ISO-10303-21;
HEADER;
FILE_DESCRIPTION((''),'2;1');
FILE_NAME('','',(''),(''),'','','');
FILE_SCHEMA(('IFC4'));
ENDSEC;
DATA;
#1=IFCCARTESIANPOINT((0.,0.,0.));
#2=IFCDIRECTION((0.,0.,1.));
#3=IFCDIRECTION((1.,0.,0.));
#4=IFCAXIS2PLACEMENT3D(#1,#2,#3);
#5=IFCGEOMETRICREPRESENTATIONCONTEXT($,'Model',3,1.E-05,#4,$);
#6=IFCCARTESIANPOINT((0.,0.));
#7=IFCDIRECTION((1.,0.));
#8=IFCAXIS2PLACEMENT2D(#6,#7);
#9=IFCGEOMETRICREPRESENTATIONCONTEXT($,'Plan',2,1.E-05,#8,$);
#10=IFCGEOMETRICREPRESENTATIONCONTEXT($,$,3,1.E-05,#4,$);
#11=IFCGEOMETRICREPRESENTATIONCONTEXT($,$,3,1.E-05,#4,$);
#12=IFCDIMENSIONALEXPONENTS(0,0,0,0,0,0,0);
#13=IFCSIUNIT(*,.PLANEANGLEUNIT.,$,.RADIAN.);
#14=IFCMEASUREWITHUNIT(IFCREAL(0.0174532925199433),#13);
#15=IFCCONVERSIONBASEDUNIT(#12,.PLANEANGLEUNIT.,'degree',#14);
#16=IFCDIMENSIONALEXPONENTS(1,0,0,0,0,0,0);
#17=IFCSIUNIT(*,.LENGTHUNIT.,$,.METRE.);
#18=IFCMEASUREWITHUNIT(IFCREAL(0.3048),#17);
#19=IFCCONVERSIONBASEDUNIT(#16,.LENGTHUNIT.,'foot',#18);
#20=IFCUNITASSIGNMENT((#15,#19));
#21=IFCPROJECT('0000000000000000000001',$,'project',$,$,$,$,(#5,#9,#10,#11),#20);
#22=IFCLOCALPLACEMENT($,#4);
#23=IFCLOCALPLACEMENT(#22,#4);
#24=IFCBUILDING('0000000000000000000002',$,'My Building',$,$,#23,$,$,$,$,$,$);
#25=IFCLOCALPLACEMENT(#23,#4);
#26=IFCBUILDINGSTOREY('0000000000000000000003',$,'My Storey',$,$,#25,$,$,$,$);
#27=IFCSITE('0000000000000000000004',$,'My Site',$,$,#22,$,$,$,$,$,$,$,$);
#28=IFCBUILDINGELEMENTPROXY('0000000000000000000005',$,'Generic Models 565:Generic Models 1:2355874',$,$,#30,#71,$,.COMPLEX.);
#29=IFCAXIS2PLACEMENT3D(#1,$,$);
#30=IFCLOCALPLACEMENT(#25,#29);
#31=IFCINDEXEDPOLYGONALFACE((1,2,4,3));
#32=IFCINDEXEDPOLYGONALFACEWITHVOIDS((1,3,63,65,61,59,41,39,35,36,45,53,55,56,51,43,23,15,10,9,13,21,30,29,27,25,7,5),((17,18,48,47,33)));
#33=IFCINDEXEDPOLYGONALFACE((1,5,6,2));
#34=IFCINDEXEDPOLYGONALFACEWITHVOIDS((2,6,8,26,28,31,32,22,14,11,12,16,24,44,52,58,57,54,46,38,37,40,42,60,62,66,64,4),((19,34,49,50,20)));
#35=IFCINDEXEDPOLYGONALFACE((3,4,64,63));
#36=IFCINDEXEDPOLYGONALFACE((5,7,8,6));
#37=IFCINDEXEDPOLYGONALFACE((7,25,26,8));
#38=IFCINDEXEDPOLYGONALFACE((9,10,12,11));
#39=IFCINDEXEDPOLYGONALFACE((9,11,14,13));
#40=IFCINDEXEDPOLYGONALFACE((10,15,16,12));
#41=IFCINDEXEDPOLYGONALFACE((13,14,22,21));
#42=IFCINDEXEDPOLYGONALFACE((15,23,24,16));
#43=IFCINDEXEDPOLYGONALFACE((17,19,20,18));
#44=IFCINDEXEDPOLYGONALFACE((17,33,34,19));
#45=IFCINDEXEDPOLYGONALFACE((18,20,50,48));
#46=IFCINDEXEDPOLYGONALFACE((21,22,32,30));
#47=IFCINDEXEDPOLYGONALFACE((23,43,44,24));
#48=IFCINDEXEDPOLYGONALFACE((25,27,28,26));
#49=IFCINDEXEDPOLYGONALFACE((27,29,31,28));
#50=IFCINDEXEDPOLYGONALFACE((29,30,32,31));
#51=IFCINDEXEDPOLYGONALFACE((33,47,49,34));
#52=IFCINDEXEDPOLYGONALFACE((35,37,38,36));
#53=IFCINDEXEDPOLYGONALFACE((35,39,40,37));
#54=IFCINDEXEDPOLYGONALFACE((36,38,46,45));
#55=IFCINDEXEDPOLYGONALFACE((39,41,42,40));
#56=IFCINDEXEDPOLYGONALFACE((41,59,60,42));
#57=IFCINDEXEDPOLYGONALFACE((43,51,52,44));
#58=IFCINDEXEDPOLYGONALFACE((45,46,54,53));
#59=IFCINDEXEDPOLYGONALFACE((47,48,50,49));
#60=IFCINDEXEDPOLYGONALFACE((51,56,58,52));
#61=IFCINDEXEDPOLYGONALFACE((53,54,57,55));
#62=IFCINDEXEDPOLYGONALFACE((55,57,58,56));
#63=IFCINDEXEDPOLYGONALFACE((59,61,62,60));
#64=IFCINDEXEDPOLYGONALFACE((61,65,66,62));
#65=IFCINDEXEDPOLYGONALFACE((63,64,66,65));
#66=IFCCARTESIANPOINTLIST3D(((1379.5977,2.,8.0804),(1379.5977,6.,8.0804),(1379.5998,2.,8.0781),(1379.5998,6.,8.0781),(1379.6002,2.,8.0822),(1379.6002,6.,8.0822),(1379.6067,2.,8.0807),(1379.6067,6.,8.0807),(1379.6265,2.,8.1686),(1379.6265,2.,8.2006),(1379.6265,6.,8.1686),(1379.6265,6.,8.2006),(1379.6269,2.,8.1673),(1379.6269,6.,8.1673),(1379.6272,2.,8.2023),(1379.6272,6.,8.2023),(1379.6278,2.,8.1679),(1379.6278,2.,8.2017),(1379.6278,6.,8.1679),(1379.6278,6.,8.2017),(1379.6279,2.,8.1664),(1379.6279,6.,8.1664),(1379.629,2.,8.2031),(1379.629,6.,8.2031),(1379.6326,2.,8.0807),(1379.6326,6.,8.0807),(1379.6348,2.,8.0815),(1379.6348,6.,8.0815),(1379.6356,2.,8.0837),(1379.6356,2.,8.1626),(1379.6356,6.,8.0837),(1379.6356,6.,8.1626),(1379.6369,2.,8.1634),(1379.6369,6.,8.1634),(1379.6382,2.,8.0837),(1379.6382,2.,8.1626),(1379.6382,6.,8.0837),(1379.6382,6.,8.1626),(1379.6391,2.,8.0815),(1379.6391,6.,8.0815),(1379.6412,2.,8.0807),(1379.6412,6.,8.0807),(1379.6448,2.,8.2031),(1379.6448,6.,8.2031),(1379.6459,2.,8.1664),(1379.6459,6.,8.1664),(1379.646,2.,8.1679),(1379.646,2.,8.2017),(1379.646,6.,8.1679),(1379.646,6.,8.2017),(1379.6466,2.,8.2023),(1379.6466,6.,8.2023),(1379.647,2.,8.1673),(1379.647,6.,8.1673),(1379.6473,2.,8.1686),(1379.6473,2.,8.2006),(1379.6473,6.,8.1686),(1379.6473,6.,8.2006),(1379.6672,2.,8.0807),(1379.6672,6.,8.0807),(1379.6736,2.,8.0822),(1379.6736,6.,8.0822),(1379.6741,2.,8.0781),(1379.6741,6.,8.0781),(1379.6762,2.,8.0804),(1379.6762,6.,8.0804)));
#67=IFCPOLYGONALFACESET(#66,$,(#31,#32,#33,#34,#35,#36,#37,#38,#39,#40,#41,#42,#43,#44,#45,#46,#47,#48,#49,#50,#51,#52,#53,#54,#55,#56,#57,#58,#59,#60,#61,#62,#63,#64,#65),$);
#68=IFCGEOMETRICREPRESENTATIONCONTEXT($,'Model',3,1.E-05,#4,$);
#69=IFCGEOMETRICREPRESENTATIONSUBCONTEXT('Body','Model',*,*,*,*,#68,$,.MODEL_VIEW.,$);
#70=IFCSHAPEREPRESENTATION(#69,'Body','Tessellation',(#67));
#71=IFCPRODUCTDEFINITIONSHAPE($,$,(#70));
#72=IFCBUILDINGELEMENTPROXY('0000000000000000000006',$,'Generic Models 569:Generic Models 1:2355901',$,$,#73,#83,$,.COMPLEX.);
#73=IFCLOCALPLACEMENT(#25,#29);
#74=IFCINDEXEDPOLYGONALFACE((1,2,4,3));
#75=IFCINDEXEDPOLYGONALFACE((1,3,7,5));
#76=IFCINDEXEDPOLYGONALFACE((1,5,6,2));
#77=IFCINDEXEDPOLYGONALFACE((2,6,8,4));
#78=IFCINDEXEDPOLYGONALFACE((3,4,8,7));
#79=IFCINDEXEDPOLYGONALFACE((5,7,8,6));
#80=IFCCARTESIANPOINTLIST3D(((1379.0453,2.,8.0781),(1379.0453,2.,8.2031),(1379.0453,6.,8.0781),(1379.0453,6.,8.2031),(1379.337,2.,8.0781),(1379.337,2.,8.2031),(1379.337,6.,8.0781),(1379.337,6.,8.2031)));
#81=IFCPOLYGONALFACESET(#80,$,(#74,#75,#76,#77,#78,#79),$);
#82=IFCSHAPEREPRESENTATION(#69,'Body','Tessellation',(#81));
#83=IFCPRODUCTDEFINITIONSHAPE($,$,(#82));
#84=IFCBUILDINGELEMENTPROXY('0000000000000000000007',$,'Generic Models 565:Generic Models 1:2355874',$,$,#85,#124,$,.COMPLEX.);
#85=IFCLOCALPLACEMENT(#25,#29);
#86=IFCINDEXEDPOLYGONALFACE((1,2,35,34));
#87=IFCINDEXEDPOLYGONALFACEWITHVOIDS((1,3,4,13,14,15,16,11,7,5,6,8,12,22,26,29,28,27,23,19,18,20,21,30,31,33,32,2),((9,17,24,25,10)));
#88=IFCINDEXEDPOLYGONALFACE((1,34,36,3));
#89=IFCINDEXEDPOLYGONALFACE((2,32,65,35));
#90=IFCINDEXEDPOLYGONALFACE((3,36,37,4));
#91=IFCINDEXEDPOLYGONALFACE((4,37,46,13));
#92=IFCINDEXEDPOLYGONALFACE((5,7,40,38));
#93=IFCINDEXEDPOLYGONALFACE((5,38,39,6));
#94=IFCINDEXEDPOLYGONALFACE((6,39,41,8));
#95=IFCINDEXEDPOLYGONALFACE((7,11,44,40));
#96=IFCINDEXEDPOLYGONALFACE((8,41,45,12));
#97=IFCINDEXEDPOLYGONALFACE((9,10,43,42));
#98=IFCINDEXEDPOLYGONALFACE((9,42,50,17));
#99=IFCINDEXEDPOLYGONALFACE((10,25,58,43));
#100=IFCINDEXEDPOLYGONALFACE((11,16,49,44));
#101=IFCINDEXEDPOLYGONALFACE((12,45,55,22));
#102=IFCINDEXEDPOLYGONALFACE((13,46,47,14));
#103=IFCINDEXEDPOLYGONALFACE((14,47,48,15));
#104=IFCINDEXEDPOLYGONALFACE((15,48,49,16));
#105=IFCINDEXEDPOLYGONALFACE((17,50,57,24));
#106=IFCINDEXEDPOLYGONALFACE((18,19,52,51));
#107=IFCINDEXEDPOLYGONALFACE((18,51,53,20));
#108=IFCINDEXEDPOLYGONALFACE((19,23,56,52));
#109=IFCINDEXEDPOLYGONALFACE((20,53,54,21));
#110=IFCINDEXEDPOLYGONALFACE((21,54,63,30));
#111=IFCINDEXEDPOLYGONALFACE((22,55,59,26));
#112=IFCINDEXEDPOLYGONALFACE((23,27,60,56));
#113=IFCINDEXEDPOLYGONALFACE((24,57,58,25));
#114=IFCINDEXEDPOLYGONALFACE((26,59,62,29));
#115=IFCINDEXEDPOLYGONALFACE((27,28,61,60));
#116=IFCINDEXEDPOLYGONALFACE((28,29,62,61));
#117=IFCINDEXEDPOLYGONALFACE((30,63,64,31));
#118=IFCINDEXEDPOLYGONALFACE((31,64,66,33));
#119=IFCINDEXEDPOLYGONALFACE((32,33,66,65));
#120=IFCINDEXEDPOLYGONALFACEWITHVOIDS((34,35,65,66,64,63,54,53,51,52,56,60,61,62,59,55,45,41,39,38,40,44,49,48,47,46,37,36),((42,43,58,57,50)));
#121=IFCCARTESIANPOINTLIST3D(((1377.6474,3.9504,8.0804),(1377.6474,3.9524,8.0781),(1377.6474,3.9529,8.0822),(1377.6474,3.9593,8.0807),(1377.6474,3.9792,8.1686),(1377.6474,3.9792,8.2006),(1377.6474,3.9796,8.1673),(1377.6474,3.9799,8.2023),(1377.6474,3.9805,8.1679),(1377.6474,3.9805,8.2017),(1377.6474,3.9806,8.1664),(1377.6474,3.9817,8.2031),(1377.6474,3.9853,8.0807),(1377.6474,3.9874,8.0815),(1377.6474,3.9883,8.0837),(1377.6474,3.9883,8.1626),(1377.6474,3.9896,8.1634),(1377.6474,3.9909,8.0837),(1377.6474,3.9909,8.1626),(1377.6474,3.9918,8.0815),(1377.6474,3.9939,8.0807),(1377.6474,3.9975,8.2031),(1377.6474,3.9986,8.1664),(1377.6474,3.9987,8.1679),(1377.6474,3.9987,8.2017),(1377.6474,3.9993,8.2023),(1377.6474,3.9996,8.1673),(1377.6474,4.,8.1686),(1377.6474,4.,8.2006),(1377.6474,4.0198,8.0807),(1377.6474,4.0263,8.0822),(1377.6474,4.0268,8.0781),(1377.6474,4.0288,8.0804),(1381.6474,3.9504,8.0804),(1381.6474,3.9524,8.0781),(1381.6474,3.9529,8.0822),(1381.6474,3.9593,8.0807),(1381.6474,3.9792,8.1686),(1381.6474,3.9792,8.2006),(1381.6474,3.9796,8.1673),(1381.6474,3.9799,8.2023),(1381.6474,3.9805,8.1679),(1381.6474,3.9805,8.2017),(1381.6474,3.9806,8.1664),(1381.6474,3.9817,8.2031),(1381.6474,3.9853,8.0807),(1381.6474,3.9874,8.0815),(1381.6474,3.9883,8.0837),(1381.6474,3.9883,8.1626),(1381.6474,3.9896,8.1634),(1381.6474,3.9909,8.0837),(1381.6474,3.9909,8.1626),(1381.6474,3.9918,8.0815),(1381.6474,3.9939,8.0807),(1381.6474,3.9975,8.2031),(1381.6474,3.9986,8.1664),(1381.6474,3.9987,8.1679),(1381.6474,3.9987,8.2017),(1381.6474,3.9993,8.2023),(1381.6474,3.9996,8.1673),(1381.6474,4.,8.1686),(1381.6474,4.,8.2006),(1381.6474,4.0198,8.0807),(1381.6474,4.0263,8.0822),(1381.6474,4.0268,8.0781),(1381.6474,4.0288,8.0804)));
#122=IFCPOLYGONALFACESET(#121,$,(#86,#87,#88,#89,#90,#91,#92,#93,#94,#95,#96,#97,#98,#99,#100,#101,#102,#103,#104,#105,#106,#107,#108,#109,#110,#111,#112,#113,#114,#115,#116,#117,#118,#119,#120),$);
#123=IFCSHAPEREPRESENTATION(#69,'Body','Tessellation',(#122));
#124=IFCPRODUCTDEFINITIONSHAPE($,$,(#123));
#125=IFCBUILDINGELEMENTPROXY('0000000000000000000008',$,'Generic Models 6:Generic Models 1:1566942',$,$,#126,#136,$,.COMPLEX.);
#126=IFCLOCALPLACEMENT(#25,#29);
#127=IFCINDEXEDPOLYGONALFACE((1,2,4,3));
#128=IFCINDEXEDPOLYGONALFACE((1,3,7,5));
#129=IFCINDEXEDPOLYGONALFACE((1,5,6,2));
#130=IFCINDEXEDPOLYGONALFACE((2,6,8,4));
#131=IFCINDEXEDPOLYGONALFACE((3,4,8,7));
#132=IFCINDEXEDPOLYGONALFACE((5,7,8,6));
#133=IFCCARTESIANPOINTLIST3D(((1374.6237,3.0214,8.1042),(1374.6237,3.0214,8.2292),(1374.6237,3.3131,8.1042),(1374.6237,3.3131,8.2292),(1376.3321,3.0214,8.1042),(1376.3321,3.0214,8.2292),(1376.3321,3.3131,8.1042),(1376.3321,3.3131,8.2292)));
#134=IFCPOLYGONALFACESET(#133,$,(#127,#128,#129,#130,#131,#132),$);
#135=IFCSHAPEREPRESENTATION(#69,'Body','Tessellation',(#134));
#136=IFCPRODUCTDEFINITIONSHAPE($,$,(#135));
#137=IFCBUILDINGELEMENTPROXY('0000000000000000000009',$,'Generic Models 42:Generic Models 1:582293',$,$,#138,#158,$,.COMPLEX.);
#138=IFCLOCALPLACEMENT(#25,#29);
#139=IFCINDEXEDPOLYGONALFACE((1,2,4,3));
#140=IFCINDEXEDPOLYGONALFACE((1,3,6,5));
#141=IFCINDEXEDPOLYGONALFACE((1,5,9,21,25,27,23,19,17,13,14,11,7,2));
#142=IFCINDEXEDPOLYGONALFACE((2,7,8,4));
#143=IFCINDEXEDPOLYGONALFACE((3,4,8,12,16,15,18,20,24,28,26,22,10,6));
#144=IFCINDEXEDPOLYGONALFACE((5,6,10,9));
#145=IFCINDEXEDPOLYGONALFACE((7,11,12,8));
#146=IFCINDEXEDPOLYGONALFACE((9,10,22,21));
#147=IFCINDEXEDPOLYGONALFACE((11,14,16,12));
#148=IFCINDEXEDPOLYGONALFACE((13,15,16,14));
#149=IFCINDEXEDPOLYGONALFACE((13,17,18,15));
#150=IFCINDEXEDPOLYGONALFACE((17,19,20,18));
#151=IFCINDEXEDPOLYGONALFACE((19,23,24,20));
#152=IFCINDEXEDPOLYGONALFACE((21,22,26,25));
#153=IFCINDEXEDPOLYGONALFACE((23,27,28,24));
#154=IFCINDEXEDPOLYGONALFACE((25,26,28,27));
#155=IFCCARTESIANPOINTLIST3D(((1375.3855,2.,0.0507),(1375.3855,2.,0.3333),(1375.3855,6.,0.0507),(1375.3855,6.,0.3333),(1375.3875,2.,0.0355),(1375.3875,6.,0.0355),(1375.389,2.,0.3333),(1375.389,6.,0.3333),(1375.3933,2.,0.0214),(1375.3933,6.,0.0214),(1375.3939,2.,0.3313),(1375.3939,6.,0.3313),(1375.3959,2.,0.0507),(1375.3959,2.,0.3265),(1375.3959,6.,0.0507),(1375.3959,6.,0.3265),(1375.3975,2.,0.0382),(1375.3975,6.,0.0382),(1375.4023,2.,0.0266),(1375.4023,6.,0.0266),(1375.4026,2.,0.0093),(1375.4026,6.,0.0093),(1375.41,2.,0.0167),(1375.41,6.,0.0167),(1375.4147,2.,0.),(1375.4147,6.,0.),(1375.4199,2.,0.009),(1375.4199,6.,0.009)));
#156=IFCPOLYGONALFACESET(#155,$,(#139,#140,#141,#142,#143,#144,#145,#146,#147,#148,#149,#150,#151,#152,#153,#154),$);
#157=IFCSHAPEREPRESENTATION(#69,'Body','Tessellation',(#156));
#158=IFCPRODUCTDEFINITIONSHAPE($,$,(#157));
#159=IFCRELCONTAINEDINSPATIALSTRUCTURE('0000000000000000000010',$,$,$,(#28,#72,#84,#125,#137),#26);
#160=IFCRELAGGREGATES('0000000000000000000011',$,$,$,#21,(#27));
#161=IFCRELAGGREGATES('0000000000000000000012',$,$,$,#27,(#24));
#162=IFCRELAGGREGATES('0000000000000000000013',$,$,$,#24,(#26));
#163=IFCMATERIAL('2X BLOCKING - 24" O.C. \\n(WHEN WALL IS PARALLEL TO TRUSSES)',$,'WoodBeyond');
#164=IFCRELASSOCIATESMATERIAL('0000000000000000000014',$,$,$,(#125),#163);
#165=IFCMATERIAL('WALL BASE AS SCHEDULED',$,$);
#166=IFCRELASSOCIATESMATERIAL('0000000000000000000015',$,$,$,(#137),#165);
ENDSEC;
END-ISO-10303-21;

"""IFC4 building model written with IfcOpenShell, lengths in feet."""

from ifc_helpers import new_model, entity, si_unit, converted_unit, frame, origin_with_axes, origin_2d_with_axis, place, context, subcontext, project, spatial, polyline, line, indexed_curve, outline, extrude, material, element, save


model = new_model("IFC4")

# Units and contexts
model_context_1 = context("Model", 3, precision=1e-05, world=origin_with_axes())
plan_context = context("Plan", 2, precision=1e-05, world=origin_2d_with_axis())
model_context_2 = context("Model", 3, precision=1e-05, world=origin_with_axes())
context_of_model_1 = context(None, 3, precision=1e-05, world=origin_with_axes())
context_of_model_2 = context(None, 3, precision=1e-05, world=origin_with_axes())
body_context = subcontext(model_context_2, "Body", "Model", "MODEL_VIEW")
ifc_project = project(units=[converted_unit("PLANEANGLEUNIT", "degree", entity("IfcReal", 0.0174532925199433), si_unit("PLANEANGLEUNIT", "RADIAN"), dimensions=[0, 0, 0, 0, 0, 0, 0]), converted_unit("LENGTHUNIT", "foot", entity("IfcReal", 0.3048), si_unit("LENGTHUNIT", "METRE"), dimensions=[1, 0, 0, 0, 0, 0, 0])], contexts=[model_context_1, plan_context, context_of_model_1, context_of_model_2])

# Site, building, storey
site_placement = place(None, origin_with_axes())
site = spatial("IfcSite", under=ifc_project, at=site_placement, Name="My Site")
building_placement = place(site_placement, origin_with_axes())
building = spatial("IfcBuilding", under=site, at=building_placement, Name="My Building")
storey_placement = place(building_placement, origin_with_axes())
storey = spatial("IfcBuildingStorey", under=building, at=storey_placement, Name="My Storey")

# Building element proxies
ifc_material_1 = material(Name="WALL BASE AS SCHEDULED")
proxy_1_placement = place(storey_placement, frame((1379.5977, 6.0, 8.0781), z_axis=(0.0, -1.0, 0.0), x_axis=(0.0, 0.0, 1.0)))
element("IfcBuildingElementProxy", 1, at=proxy_1_placement, inside=storey, Name="Generic Models 565:Generic Models 1:2355874", PredefinedType="COMPLEX", context=body_context, shape_type="SweptSolid", body=[
    extrude(outline(indexed_curve([(0.0297, 0.0058), (0.0311, 0.006), (0.0627, 0.0015), (0.0643, 0.0005), (0.0648, -0.0014), (0.0625, -0.017), (0.0615, -0.0187), (0.0597, -0.0192), (0.0281, -0.0146), (0.0268, -0.014), (0.0261, -0.0129), (0.0234, -0.0047), (-0.0547, 0.0066), (-0.0569, 0.006), (-0.0581, 0.0041), (-0.0618, -0.0216), (-0.0612, -0.0282), (-0.0634, -0.0305), (-0.0654, -0.0281), (-0.0547, 0.0455), (-0.0522, 0.0472), (-0.0507, 0.0444), (-0.0532, 0.0382), (-0.0569, 0.0126), (-0.0563, 0.0103), (-0.0543, 0.0092), (0.0238, -0.0021), (0.0286, 0.005), (0.0301, 0.0048), (0.0637, 0.0), (0.0611, -0.018), (0.0275, -0.0132), (0.0244, -0.0035)], segments=[line(7, 6), line(6, 5), line(5, 4), line(4, 3), line(3, 2), line(2, 1), line(1, 28), line(28, 27), line(27, 26), line(26, 25), line(25, 24), line(24, 23), line(23, 22), line(22, 21), line(21, 20), line(20, 19), line(19, 18), line(18, 17), line(17, 16), line(16, 15), line(15, 14), line(14, 13), line(13, 12), line(12, 11), line(11, 10), line(10, 9), line(9, 8), line(8, 7)], self_intersect=False), holes=[indexed_curve([(0.0297, 0.0058), (0.0311, 0.006), (0.0627, 0.0015), (0.0643, 0.0005), (0.0648, -0.0014), (0.0625, -0.017), (0.0615, -0.0187), (0.0597, -0.0192), (0.0281, -0.0146), (0.0268, -0.014), (0.0261, -0.0129), (0.0234, -0.0047), (-0.0547, 0.0066), (-0.0569, 0.006), (-0.0581, 0.0041), (-0.0618, -0.0216), (-0.0612, -0.0282), (-0.0634, -0.0305), (-0.0654, -0.0281), (-0.0547, 0.0455), (-0.0522, 0.0472), (-0.0507, 0.0444), (-0.0532, 0.0382), (-0.0569, 0.0126), (-0.0563, 0.0103), (-0.0543, 0.0092), (0.0238, -0.0021), (0.0286, 0.005), (0.0301, 0.0048), (0.0637, 0.0), (0.0611, -0.018), (0.0275, -0.0132), (0.0244, -0.0035)], segments=[line(31, 32), line(32, 33), line(33, 29), line(29, 30), line(30, 31)], self_intersect=False)]), frame((0.0607, -0.0392, 0.0), z_axis=(0.0, 0.0, -1.0), x_axis=(0.989698, -0.14317, 0.0)), (0.0, 0.0, -1.0), 4.0),
])
proxy_2_placement = place(storey_placement, frame((1379.0453, 6.0, 8.0781), z_axis=(0.0, -1.0, 0.0), x_axis=(0.0, 0.0, 1.0)))
element("IfcBuildingElementProxy", 2, at=proxy_2_placement, inside=storey, Name="Generic Models 569:Generic Models 1:2355901", PredefinedType="COMPLEX", context=body_context, shape_type="SweptSolid", body=[
    extrude(outline(polyline([(-0.1458, -0.0625), (0.1458, -0.0625), (0.1458, 0.0625), (-0.1458, 0.0625), (-0.1458, -0.0625)])), frame((0.0625, -0.1458, 0.0), z_axis=(0.0, 0.0, -1.0), x_axis=(0.0, 1.0, 0.0)), (0.0, 0.0, -1.0), 4.0),
])
proxy_3_placement = place(storey_placement, frame((1377.6474, 3.9503, 8.0781), z_axis=(1.0, 0.0, 0.0), x_axis=(0.0, 0.0, 1.0)))
element("IfcBuildingElementProxy", 3, at=proxy_3_placement, inside=storey, Name="Generic Models 565:Generic Models 1:2355874", PredefinedType="COMPLEX", context=body_context, shape_type="SweptSolid", body=[
    extrude(outline(indexed_curve([(0.0297, 0.0058), (0.0311, 0.006), (0.0627, 0.0015), (0.0643, 0.0005), (0.0648, -0.0014), (0.0625, -0.017), (0.0615, -0.0187), (0.0597, -0.0192), (0.0281, -0.0146), (0.0268, -0.014), (0.0261, -0.0129), (0.0234, -0.0047), (-0.0547, 0.0066), (-0.0569, 0.006), (-0.0581, 0.0041), (-0.0618, -0.0216), (-0.0612, -0.0282), (-0.0634, -0.0305), (-0.0654, -0.0281), (-0.0547, 0.0455), (-0.0522, 0.0472), (-0.0507, 0.0444), (-0.0532, 0.0382), (-0.0569, 0.0126), (-0.0563, 0.0103), (-0.0543, 0.0092), (0.0238, -0.0021), (0.0286, 0.005), (0.0301, 0.0048), (0.0637, 0.0), (0.0611, -0.018), (0.0275, -0.0132), (0.0244, -0.0035)], segments=[line(7, 6), line(6, 5), line(5, 4), line(4, 3), line(3, 2), line(2, 1), line(1, 28), line(28, 27), line(27, 26), line(26, 25), line(25, 24), line(24, 23), line(23, 22), line(22, 21), line(21, 20), line(20, 19), line(19, 18), line(18, 17), line(17, 16), line(16, 15), line(15, 14), line(14, 13), line(13, 12), line(12, 11), line(11, 10), line(10, 9), line(9, 8), line(8, 7)], self_intersect=False), holes=[indexed_curve([(0.0297, 0.0058), (0.0311, 0.006), (0.0627, 0.0015), (0.0643, 0.0005), (0.0648, -0.0014), (0.0625, -0.017), (0.0615, -0.0187), (0.0597, -0.0192), (0.0281, -0.0146), (0.0268, -0.014), (0.0261, -0.0129), (0.0234, -0.0047), (-0.0547, 0.0066), (-0.0569, 0.006), (-0.0581, 0.0041), (-0.0618, -0.0216), (-0.0612, -0.0282), (-0.0634, -0.0305), (-0.0654, -0.0281), (-0.0547, 0.0455), (-0.0522, 0.0472), (-0.0507, 0.0444), (-0.0532, 0.0382), (-0.0569, 0.0126), (-0.0563, 0.0103), (-0.0543, 0.0092), (0.0238, -0.0021), (0.0286, 0.005), (0.0301, 0.0048), (0.0637, 0.0), (0.0611, -0.018), (0.0275, -0.0132), (0.0244, -0.0035)], segments=[line(31, 32), line(32, 33), line(33, 29), line(29, 30), line(30, 31)], self_intersect=False)]), frame((0.0607, -0.0392, 0.0), z_axis=(0.0, 0.0, -1.0), x_axis=(0.989698, -0.14317, 0.0)), (0.0, 0.0, -1.0), 4.0),
])
ifc_material_2 = material(Name="2X BLOCKING - 24\" O.C. \\n(WHEN WALL IS PARALLEL TO TRUSSES)", Category="WoodBeyond")
proxy_4_placement = place(storey_placement, frame((1376.3321, 3.3131, 8.1042), z_axis=(-1.0, 0.0, 0.0), x_axis=(0.0, 0.0, -1.0)))
element("IfcBuildingElementProxy", 4, at=proxy_4_placement, inside=storey, material=ifc_material_2, Name="Generic Models 6:Generic Models 1:1566942", PredefinedType="COMPLEX", context=body_context, shape_type="SweptSolid", body=[
    extrude(outline(indexed_curve([(-0.0625, -0.1458), (0.0625, -0.1458), (0.0625, 0.1458), (-0.0625, 0.1458)], segments=[line(4, 1), line(1, 2), line(2, 3), line(3, 4)], self_intersect=False)), frame((-0.0625, 0.1458, 0.0), z_axis=(0.0, 0.0, -1.0), x_axis=(1.0, 0.0, 0.0)), (0.0, 0.0, -1.0), 1.7083),
])
proxy_5_placement = place(storey_placement, frame((1375.3855, 6.0, 0.0), z_axis=(0.0, -1.0, 0.0), x_axis=(0.0, 0.0, -1.0)))
element("IfcBuildingElementProxy", 5, at=proxy_5_placement, inside=storey, material=ifc_material_1, Name="Generic Models 42:Generic Models 1:582293", PredefinedType="COMPLEX", context=body_context, shape_type="SweptSolid", body=[
    extrude(outline(polyline([(-0.0624, -0.0126), (0.2203, -0.0126), (0.2203, -0.0091), (0.2183, -0.0042), (0.2134, -0.0022), (-0.0624, -0.0022), (-0.0748, -0.0006), (-0.0864, 0.0042), (-0.0964, 0.0119), (-0.104, 0.0218), (-0.113, 0.0166), (-0.1037, 0.0045), (-0.0916, -0.0048), (-0.0775, -0.0106), (-0.0624, -0.0126)])), frame((-0.113, 0.0126, 0.0), z_axis=(0.0, 0.0, -1.0), x_axis=(-1.0, 0.0, 0.0)), (0.0, 0.0, -1.0), 4.0),
])

save(model, "model.ifc")
